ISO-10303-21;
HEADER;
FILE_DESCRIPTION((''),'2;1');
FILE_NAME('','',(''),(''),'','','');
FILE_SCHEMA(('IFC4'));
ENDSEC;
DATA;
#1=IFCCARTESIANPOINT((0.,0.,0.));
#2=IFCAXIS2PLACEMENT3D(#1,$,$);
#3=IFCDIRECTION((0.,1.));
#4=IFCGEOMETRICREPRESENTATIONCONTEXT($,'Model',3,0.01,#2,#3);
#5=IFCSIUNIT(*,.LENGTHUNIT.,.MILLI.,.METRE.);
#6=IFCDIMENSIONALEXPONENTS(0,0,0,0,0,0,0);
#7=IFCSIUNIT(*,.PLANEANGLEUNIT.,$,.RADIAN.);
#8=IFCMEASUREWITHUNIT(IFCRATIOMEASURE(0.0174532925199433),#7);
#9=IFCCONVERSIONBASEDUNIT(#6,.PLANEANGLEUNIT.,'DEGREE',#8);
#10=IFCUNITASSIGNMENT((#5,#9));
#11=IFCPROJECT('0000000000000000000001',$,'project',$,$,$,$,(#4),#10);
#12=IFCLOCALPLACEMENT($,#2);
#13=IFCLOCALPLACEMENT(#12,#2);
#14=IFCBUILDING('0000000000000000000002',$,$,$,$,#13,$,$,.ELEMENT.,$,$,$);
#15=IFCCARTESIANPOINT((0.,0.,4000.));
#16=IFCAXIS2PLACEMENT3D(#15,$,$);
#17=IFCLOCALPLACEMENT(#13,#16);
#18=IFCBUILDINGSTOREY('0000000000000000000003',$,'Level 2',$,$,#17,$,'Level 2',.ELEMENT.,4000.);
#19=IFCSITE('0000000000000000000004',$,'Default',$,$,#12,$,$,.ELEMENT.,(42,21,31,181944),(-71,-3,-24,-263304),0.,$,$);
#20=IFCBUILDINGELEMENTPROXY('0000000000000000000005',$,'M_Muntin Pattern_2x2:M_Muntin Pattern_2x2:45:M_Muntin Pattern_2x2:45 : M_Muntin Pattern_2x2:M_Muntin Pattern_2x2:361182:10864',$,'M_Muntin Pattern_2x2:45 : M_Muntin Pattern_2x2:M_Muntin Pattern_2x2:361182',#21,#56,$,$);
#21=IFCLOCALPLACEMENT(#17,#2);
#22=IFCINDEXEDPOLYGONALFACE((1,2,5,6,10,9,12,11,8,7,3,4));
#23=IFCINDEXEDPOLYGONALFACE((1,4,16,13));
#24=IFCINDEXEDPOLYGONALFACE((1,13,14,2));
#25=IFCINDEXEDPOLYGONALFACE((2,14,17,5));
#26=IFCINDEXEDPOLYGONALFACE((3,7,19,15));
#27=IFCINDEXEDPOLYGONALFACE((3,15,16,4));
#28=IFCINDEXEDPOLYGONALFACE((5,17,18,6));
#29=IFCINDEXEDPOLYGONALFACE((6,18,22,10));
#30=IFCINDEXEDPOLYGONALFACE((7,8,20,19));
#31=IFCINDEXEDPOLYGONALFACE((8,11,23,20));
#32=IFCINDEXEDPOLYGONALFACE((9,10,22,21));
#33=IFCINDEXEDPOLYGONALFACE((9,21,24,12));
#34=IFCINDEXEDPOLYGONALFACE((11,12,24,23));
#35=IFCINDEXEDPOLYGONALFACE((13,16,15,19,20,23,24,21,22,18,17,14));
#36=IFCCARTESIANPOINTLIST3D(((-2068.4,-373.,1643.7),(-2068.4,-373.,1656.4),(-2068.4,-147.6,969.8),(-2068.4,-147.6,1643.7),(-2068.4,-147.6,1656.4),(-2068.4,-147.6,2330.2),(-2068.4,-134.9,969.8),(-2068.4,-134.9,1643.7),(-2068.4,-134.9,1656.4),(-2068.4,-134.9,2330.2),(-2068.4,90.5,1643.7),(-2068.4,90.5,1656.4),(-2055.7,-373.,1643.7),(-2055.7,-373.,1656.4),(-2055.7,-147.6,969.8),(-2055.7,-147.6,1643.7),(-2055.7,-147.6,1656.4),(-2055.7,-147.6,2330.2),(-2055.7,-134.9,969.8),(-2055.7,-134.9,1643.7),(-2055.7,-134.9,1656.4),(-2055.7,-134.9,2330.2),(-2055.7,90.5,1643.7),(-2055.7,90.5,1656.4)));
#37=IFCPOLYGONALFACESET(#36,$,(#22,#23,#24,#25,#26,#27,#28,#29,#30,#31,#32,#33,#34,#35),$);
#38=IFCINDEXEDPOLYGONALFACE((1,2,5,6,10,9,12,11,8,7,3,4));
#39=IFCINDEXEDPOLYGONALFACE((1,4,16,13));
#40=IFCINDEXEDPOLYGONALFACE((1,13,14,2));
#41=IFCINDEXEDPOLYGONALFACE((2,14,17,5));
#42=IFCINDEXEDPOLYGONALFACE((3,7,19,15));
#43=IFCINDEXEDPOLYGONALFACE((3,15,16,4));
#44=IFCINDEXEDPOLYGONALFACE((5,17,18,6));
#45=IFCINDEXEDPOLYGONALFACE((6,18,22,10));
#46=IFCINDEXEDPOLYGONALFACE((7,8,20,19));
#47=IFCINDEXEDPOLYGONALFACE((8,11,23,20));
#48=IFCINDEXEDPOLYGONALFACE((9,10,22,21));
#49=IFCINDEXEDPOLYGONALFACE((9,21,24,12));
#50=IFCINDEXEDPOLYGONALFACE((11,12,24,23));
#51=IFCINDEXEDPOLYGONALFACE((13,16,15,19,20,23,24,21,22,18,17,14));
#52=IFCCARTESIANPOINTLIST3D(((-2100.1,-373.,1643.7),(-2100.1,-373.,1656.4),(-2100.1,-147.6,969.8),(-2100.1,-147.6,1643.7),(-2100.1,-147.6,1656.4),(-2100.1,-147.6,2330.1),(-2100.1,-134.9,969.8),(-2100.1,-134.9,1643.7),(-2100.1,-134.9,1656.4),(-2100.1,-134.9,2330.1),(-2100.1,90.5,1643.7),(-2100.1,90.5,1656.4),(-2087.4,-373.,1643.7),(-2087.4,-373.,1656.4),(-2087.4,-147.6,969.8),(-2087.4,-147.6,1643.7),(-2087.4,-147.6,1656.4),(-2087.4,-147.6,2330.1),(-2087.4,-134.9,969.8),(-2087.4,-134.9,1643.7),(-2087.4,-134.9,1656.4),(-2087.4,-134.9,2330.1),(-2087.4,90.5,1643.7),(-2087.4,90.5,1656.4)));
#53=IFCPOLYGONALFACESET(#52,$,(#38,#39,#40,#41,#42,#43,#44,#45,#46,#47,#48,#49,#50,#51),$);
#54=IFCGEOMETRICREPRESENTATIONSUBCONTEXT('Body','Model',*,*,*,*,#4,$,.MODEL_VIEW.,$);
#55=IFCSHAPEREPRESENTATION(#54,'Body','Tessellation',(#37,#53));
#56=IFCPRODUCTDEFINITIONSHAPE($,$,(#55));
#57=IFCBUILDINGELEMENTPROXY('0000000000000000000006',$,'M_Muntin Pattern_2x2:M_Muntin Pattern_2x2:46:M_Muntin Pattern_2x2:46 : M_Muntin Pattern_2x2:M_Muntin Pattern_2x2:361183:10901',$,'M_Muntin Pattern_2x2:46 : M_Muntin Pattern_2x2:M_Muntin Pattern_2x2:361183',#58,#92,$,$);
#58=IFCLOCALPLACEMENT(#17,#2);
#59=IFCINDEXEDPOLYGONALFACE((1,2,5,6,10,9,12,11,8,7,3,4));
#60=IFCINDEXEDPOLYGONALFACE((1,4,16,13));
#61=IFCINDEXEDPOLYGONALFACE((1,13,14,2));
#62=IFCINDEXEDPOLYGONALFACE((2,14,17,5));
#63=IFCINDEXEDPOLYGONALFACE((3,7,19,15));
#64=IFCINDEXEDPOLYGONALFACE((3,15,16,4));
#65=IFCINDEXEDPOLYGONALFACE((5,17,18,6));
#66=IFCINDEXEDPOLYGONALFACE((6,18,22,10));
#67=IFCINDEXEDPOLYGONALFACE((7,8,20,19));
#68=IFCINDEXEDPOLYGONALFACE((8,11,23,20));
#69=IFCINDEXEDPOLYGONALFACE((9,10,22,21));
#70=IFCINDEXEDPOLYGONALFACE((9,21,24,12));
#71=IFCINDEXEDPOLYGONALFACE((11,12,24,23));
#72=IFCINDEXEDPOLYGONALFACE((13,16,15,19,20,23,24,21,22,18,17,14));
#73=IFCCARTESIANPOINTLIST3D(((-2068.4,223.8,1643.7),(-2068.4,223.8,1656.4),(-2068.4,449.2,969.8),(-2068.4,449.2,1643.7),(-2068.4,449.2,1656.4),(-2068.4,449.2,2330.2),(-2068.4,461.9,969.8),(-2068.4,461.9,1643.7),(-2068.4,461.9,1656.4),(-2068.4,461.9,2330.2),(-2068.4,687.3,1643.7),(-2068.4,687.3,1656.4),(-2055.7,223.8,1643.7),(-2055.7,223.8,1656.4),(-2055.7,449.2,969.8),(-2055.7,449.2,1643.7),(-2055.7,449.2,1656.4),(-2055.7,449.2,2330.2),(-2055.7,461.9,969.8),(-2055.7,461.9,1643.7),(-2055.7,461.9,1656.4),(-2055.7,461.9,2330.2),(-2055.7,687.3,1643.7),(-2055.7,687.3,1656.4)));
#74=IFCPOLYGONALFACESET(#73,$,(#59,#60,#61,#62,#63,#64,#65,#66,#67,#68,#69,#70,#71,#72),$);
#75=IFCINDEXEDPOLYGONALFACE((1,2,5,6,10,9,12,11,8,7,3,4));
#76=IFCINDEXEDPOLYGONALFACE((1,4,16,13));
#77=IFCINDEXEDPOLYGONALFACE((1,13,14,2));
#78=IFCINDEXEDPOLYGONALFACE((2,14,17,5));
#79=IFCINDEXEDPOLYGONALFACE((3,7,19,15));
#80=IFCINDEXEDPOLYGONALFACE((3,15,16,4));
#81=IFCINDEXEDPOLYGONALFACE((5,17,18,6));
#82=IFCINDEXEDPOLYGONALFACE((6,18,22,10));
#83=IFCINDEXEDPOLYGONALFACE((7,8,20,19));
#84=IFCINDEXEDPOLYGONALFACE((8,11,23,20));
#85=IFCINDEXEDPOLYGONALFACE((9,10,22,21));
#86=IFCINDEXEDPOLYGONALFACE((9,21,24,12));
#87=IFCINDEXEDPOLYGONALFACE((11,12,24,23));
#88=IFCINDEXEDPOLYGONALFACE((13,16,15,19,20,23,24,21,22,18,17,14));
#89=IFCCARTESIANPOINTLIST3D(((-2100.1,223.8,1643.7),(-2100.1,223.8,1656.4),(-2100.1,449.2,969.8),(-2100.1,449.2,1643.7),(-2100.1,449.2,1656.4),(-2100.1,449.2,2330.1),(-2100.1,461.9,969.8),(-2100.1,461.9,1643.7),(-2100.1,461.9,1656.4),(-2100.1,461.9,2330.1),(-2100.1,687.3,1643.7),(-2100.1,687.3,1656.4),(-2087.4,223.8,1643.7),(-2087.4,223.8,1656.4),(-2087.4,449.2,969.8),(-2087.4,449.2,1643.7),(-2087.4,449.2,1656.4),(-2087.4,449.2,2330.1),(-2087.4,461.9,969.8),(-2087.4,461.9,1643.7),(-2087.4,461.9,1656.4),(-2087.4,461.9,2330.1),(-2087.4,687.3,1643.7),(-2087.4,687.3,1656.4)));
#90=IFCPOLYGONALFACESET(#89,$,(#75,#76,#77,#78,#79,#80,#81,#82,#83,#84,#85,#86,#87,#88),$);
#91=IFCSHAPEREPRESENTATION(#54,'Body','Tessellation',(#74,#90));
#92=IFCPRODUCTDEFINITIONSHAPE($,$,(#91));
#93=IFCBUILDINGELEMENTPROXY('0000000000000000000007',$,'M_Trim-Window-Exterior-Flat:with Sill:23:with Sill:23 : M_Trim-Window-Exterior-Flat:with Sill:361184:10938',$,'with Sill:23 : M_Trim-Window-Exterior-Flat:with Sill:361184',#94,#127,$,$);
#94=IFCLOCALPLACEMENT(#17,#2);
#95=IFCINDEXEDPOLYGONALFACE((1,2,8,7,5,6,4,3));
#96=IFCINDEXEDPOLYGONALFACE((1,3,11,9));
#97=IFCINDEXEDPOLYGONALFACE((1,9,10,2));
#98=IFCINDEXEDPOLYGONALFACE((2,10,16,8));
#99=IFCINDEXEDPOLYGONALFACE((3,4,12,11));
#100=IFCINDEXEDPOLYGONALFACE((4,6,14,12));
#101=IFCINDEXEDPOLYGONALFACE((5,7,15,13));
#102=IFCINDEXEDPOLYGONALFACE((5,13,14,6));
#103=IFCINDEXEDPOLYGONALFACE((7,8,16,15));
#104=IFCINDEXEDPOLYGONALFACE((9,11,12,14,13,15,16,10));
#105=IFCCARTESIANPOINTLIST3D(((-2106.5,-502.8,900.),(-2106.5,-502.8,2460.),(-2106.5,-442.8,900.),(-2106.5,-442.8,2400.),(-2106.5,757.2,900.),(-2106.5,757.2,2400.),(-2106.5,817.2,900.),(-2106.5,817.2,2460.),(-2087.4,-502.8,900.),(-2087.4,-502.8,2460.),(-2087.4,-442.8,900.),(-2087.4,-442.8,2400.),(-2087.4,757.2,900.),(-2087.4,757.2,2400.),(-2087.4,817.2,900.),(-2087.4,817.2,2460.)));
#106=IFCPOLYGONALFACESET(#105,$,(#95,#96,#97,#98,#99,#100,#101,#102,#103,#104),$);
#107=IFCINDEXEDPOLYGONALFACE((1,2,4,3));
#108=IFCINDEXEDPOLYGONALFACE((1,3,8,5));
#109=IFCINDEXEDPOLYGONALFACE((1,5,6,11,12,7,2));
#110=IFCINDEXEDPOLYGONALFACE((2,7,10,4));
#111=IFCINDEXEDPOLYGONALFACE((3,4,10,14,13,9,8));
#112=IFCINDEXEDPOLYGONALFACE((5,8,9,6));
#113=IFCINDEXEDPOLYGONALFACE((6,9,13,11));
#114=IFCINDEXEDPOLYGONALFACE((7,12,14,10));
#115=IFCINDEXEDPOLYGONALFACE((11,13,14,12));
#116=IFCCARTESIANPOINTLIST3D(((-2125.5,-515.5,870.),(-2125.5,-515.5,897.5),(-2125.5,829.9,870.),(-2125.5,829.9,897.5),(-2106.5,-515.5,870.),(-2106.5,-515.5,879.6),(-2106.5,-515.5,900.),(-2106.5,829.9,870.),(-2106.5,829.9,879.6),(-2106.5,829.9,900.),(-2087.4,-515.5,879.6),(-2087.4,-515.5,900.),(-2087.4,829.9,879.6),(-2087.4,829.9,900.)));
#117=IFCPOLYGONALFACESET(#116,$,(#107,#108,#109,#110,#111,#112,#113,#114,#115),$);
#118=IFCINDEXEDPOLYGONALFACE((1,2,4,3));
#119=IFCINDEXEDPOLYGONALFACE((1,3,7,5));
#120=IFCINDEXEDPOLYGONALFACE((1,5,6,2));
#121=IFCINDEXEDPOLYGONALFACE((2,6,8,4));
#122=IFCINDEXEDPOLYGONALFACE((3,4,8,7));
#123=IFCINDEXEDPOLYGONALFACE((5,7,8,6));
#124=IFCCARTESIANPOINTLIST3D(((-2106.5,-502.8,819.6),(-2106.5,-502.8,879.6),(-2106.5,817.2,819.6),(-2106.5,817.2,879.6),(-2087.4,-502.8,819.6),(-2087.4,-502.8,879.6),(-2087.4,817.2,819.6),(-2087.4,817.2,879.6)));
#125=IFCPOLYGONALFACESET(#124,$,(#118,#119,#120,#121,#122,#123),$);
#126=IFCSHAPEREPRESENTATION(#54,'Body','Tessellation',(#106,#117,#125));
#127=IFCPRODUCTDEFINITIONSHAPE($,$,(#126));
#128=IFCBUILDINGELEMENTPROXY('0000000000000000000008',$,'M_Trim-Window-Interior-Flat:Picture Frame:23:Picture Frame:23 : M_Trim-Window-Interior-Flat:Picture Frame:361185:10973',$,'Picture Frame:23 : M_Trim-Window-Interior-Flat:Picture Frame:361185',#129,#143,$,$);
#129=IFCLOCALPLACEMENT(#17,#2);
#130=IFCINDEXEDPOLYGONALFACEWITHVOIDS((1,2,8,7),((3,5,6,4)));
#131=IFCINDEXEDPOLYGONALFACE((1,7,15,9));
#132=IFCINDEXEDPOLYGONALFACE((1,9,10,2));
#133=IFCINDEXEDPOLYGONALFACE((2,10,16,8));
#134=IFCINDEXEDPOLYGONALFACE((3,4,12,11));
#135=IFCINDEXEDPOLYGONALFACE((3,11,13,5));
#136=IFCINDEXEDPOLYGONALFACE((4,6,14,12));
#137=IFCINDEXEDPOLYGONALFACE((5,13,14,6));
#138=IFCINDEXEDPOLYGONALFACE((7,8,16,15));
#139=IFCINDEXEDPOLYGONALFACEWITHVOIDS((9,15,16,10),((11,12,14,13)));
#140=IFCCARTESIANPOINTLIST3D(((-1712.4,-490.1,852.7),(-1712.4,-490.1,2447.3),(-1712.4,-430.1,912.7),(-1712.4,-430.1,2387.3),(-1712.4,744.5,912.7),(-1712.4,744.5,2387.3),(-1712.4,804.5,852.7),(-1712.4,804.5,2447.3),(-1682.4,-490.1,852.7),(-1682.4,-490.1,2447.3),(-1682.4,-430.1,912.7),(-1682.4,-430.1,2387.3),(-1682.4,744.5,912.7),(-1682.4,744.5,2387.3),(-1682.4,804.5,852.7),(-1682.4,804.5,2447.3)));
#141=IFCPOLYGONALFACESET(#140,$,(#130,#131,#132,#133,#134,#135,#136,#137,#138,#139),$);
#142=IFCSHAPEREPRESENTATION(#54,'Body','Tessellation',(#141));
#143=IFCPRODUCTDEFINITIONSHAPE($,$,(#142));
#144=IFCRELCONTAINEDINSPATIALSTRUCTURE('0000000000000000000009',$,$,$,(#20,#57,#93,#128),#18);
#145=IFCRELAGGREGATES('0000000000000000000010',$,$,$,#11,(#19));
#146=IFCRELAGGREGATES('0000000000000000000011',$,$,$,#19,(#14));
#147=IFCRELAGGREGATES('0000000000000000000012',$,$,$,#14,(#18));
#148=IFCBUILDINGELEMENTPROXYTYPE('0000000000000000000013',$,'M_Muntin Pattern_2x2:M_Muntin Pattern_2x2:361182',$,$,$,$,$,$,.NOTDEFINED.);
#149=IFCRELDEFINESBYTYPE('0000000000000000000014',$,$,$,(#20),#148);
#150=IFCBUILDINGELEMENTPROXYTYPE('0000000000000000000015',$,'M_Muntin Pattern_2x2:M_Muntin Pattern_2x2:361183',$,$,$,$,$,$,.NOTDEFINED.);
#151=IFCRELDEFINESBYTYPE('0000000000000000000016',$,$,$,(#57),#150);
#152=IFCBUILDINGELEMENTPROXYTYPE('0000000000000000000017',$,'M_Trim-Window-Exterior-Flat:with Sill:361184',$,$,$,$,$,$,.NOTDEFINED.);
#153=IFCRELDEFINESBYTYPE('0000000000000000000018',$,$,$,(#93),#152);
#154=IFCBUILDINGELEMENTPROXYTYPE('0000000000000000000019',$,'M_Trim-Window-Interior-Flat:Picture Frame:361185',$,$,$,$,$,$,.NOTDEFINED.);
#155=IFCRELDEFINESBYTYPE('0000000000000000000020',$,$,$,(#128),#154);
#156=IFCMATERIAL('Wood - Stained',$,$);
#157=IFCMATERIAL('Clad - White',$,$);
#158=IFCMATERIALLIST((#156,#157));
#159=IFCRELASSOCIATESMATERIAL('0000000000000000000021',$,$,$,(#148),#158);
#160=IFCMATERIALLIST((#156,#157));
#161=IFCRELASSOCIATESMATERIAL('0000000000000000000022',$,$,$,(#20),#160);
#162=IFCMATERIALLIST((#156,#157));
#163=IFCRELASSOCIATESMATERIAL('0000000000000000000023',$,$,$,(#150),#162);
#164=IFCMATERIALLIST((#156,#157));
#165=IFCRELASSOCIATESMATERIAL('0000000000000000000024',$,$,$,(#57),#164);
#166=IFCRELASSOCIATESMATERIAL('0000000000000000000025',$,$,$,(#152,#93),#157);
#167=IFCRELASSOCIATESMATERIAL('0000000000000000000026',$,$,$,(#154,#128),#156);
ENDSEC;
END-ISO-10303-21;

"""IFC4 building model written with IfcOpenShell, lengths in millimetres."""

from ifc_helpers import new_model, entity, si_unit, converted_unit, direction, frame, origin, origin_2d_with_axis, place, context, subcontext, project, spatial, polyline, rectangle, outline, extrude, source, transform, mapped, material, material_list, type_object, type_shapes, element, save


model = new_model("IFC4")

# Units and contexts
model_context = context("Model", 3, precision=0.01, world=origin(), true_north=direction((0.0, 1.0)))
body_context = subcontext(model_context, "Body", "Model", "MODEL_VIEW")
ifc_project = project(units=[si_unit("LENGTHUNIT", "METRE", prefix="MILLI"), converted_unit("PLANEANGLEUNIT", "DEGREE", entity("IfcRatioMeasure", 0.0174532925199433), si_unit("PLANEANGLEUNIT", "RADIAN"), dimensions=[0, 0, 0, 0, 0, 0, 0])], contexts=[model_context])

# Site, building, storey
site_placement = place(None, origin())
site = spatial("IfcSite", under=ifc_project, at=site_placement, Name="Default", CompositionType="ELEMENT", RefLatitude=(42, 21, 31, 181944), RefLongitude=(-71, -3, -24, -263304), RefElevation=0.0)
building_placement = place(site_placement, origin())
building = spatial("IfcBuilding", under=site, at=building_placement, CompositionType="ELEMENT")
storey_placement = place(building_placement, frame((0.0, 0.0, 4000.0)))
storey = spatial("IfcBuildingStorey", under=building, at=storey_placement, Name="Level 2", LongName="Level 2", CompositionType="ELEMENT", Elevation=4000.0)

# Building element proxies
ifc_material_1 = material(Name="Wood - Stained")
ifc_material_2 = material(Name="Clad - White")
ifc_material_list_1 = material_list([ifc_material_1, ifc_material_2])
ifc_material_list_2 = material_list([ifc_material_1, ifc_material_2])
building_element_proxy_type_1 = type_object("IfcBuildingElementProxyType", Name="M_Muntin Pattern_2x2:M_Muntin Pattern_2x2:361182", PredefinedType="NOTDEFINED", material=ifc_material_list_2)
shared_shape_1 = source(origin(), body_context, "Body", "SweptSolid", [
    extrude(outline(polyline([(-680.2, 6.4), (-680.2, -6.3), (-6.4, -6.3), (-6.4, -231.7), (6.3, -231.7), (6.3, -6.3), (680.2, -6.3), (680.2, 6.4), (6.3, 6.4), (6.3, 231.7), (-6.4, 231.7), (-6.4, 6.4), (-680.2, 6.4)])), frame((-2068.4, -141.3, 5650.0), z_axis=(-1.0, 0.0, 0.0), x_axis=(0.0, 0.0, -1.0)), (0.0, 0.0, -1.0), 12.7),
    extrude(outline(polyline([(-680.1, 6.4), (-680.1, -6.3), (-6.4, -6.3), (-6.4, -231.7), (6.3, -231.7), (6.3, -6.3), (680.2, -6.3), (680.2, 6.4), (6.3, 6.4), (6.3, 231.7), (-6.4, 231.7), (-6.4, 6.4), (-680.1, 6.4)])), frame((-2100.1, -141.3, 5650.0), z_axis=(-1.0, 0.0, 0.0), x_axis=(0.0, 0.0, -1.0)), (0.0, 0.0, -1.0), 12.7),
])
type_shapes(building_element_proxy_type_1, [shared_shape_1])
proxy_1_placement = place(storey_placement, frame((0.0, 0.0, -4000.0)))
element("IfcBuildingElementProxy", 1, at=proxy_1_placement, inside=storey, type_object=building_element_proxy_type_1, material=ifc_material_list_1, Name="M_Muntin Pattern_2x2:M_Muntin Pattern_2x2:45:M_Muntin Pattern_2x2:45 : M_Muntin Pattern_2x2:M_Muntin Pattern_2x2:361182:10864", ObjectType="M_Muntin Pattern_2x2:45 : M_Muntin Pattern_2x2:M_Muntin Pattern_2x2:361182", context=body_context, shape_type="MappedRepresentation", body=[
    mapped(shared_shape_1, transform((0.0, 0.0, 0.0), scale=1.0)),
])
ifc_material_list_3 = material_list([ifc_material_1, ifc_material_2])
ifc_material_list_4 = material_list([ifc_material_1, ifc_material_2])
building_element_proxy_type_2 = type_object("IfcBuildingElementProxyType", Name="M_Muntin Pattern_2x2:M_Muntin Pattern_2x2:361183", PredefinedType="NOTDEFINED", material=ifc_material_list_4)
shared_shape_2 = source(origin(), body_context, "Body", "SweptSolid", [
    extrude(outline(polyline([(-6.4, -680.1), (6.3, -680.1), (6.3, -6.4), (231.7, -6.4), (231.7, 6.3), (6.3, 6.3), (6.3, 680.2), (-6.4, 680.2), (-6.4, 6.3), (-231.7, 6.3), (-231.7, -6.4), (-6.4, -6.4), (-6.4, -680.1)])), frame((-2068.4, 455.6, 5650.0), z_axis=(1.0, 0.0, 0.0), x_axis=(0.0, -1.0, 0.0)), (0.0, 0.0, 1.0), 12.7),
    extrude(outline(polyline([(-6.4, -680.1), (6.3, -680.1), (6.3, -6.4), (231.7, -6.4), (231.7, 6.3), (6.3, 6.3), (6.3, 680.2), (-6.4, 680.2), (-6.4, 6.3), (-231.7, 6.3), (-231.7, -6.4), (-6.4, -6.4), (-6.4, -680.1)])), frame((-2100.1, 455.6, 5650.0), z_axis=(1.0, 0.0, 0.0), x_axis=(0.0, -1.0, 0.0)), (0.0, 0.0, 1.0), 12.7),
])
type_shapes(building_element_proxy_type_2, [shared_shape_2])
proxy_2_placement = place(storey_placement, frame((0.0, 0.0, -4000.0)))
element("IfcBuildingElementProxy", 2, at=proxy_2_placement, inside=storey, type_object=building_element_proxy_type_2, material=ifc_material_list_3, Name="M_Muntin Pattern_2x2:M_Muntin Pattern_2x2:46:M_Muntin Pattern_2x2:46 : M_Muntin Pattern_2x2:M_Muntin Pattern_2x2:361183:10901", ObjectType="M_Muntin Pattern_2x2:46 : M_Muntin Pattern_2x2:M_Muntin Pattern_2x2:361183", context=body_context, shape_type="MappedRepresentation", body=[
    mapped(shared_shape_2, transform((0.0, 0.0, 0.0), scale=1.0)),
])
building_element_proxy_type_3 = type_object("IfcBuildingElementProxyType", Name="M_Trim-Window-Exterior-Flat:with Sill:361184", PredefinedType="NOTDEFINED", material=ifc_material_2)
shared_shape_3 = source(origin(), body_context, "Body", "SweptSolid", [
    extrude(outline(polyline([(-765.0, -660.0), (795.0, -660.0), (795.0, 660.0), (-765.0, 660.0), (-765.0, 600.0), (735.0, 600.0), (735.0, -600.0), (-765.0, -600.0), (-765.0, -660.0)])), frame((-2106.5, 157.2, 5665.0), z_axis=(1.0, 0.0, 0.0), x_axis=(0.0, 0.0, 1.0)), (0.0, 0.0, 1.0), 19.1),
    extrude(outline(polyline([(0.0, -15.2), (19.0, -15.2), (19.0, 12.3), (0.0, 14.8), (-19.0, 14.8), (-19.0, -5.7), (0.0, -5.7), (0.0, -15.2)])), frame((-2106.5, -515.5, 4885.2), z_axis=(0.0, 1.0, 0.0), x_axis=(-1.0, 0.0, 0.0)), (0.0, 0.0, 1.0), 1345.4),
    extrude(rectangle(XDim=19.1, YDim=1320.0, at=origin_2d_with_axis()), frame((-2097.0, 157.2, 4819.6)), (0.0, 0.0, 1.0), 60.0),
])
type_shapes(building_element_proxy_type_3, [shared_shape_3])
proxy_3_placement = place(storey_placement, frame((0.0, 0.0, -4000.0)))
element("IfcBuildingElementProxy", 3, at=proxy_3_placement, inside=storey, type_object=building_element_proxy_type_3, material=ifc_material_2, Name="M_Trim-Window-Exterior-Flat:with Sill:23:with Sill:23 : M_Trim-Window-Exterior-Flat:with Sill:361184:10938", ObjectType="with Sill:23 : M_Trim-Window-Exterior-Flat:with Sill:361184", context=body_context, shape_type="MappedRepresentation", body=[
    mapped(shared_shape_3, transform((0.0, 0.0, 0.0), scale=1.0)),
])
building_element_proxy_type_4 = type_object("IfcBuildingElementProxyType", Name="M_Trim-Window-Interior-Flat:Picture Frame:361185", PredefinedType="NOTDEFINED", material=ifc_material_1)
shared_shape_4 = source(origin(), body_context, "Body", "SweptSolid", [
    extrude(outline(polyline([(-797.3, -647.3), (797.3, -647.3), (797.3, 647.3), (-797.3, 647.3), (-797.3, -647.3)]), holes=[polyline([(737.3, 587.3), (737.3, -587.3), (-737.3, -587.3), (-737.3, 587.3), (737.3, 587.3)])]), frame((-1712.4, 157.2, 5650.0), z_axis=(1.0, 0.0, 0.0), x_axis=(0.0, 0.0, -1.0)), (0.0, 0.0, 1.0), 30.0),
])
type_shapes(building_element_proxy_type_4, [shared_shape_4])
proxy_4_placement = place(storey_placement, frame((0.0, 0.0, -4000.0)))
element("IfcBuildingElementProxy", 4, at=proxy_4_placement, inside=storey, type_object=building_element_proxy_type_4, material=ifc_material_1, Name="M_Trim-Window-Interior-Flat:Picture Frame:23:Picture Frame:23 : M_Trim-Window-Interior-Flat:Picture Frame:361185:10973", ObjectType="Picture Frame:23 : M_Trim-Window-Interior-Flat:Picture Frame:361185", context=body_context, shape_type="MappedRepresentation", body=[
    mapped(shared_shape_4, transform((0.0, 0.0, 0.0), scale=1.0)),
])

save(model, "model.ifc")
